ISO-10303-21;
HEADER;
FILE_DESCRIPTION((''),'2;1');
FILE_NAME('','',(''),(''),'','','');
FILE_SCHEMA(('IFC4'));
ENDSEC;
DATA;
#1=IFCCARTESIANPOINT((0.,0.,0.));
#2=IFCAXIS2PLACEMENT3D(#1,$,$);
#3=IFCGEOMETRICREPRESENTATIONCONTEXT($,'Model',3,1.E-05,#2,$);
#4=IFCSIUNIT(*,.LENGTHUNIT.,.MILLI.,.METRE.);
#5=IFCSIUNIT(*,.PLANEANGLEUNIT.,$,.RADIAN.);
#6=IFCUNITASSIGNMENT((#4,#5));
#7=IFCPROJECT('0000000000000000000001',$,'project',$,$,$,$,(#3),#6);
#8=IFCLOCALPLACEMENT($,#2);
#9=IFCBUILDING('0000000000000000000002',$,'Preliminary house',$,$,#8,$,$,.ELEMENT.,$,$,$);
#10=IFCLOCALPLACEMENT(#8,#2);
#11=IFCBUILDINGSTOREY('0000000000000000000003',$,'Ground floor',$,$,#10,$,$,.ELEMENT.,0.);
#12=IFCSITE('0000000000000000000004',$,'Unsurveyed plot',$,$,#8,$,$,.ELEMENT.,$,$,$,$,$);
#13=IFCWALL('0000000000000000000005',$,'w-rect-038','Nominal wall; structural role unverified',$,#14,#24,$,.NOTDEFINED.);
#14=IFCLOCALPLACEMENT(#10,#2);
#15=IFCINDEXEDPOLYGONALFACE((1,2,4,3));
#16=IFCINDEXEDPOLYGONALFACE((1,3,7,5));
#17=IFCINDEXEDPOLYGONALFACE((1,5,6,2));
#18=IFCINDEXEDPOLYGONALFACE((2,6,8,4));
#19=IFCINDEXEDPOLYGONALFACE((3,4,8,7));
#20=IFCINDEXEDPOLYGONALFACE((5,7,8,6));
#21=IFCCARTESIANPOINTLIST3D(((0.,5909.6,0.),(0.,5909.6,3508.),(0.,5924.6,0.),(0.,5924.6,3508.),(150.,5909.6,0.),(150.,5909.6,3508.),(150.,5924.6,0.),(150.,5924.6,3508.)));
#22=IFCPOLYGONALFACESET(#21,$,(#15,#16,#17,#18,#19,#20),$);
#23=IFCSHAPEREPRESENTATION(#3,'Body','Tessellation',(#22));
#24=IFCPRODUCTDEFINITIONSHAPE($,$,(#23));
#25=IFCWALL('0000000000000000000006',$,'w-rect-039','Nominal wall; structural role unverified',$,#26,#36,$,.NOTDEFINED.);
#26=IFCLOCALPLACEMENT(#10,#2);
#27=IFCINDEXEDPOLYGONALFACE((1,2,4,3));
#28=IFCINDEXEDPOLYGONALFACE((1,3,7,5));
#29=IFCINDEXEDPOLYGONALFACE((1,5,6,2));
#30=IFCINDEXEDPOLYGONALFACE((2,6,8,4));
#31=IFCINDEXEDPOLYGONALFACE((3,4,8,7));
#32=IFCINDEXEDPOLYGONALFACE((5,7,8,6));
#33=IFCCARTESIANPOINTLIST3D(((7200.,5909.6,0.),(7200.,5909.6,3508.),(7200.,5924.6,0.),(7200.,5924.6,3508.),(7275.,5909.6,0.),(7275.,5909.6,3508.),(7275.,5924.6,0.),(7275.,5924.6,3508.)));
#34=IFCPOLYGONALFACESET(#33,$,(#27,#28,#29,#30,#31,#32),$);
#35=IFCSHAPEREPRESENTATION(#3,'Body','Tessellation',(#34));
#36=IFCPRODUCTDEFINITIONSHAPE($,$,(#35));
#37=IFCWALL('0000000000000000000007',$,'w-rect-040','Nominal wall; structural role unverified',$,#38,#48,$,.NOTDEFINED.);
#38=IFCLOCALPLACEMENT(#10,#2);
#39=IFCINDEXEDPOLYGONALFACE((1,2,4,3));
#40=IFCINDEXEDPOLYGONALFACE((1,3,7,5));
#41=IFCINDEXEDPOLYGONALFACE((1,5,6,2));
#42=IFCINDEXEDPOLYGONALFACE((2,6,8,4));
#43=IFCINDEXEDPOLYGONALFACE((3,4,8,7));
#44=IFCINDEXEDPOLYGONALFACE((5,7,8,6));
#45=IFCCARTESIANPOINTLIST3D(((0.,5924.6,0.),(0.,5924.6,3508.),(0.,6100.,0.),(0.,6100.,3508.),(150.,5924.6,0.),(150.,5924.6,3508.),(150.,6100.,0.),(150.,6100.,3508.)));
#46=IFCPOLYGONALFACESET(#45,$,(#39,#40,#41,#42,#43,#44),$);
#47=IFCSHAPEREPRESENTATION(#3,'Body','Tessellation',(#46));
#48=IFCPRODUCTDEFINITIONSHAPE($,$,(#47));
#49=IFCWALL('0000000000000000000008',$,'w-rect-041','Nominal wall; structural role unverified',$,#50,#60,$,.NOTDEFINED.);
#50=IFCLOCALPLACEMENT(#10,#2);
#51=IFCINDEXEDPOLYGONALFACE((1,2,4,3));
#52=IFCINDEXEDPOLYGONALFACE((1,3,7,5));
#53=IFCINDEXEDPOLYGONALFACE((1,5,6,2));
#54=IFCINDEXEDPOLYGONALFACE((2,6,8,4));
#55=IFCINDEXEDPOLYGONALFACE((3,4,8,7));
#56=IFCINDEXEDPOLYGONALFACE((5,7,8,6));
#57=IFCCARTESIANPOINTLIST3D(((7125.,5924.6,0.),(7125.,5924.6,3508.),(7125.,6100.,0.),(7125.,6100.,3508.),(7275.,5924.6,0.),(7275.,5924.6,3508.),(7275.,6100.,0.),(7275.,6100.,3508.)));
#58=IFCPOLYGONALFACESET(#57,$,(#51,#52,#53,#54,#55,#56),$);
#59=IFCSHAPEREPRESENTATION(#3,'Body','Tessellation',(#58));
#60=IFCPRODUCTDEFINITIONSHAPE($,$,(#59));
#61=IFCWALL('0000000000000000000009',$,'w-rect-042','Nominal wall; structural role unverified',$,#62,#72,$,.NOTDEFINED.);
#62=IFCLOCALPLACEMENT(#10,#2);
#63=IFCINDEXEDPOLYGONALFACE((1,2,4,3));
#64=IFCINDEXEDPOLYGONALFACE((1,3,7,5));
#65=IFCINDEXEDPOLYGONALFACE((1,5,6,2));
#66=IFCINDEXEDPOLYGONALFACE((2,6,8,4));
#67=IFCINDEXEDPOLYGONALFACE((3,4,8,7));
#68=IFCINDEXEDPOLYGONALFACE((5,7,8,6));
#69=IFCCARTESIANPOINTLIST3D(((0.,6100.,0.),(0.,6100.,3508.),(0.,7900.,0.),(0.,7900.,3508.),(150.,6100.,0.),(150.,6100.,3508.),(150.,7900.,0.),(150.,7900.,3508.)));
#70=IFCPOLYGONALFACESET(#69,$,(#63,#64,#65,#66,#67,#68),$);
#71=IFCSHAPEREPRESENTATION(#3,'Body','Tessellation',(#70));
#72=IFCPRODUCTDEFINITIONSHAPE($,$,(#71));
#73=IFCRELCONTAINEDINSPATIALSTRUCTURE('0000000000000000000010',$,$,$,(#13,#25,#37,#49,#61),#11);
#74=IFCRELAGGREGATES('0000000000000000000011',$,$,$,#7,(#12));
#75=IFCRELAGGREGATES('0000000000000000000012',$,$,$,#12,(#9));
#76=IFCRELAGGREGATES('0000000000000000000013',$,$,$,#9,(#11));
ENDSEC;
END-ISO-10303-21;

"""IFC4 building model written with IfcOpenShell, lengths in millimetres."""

from ifc_helpers import new_model, si_unit, origin, place, context, project, spatial, polyline, outline, extrude, element, save


model = new_model("IFC4")

# Units and contexts
model_context = context("Model", 3, precision=1e-05, world=origin())
ifc_project = project(units=[si_unit("LENGTHUNIT", "METRE", prefix="MILLI"), si_unit("PLANEANGLEUNIT", "RADIAN")], contexts=[model_context])

# Site, building, storey
placement_1 = place(None, origin())
site = spatial("IfcSite", under=ifc_project, at=placement_1, Name="Unsurveyed plot", CompositionType="ELEMENT")
building = spatial("IfcBuilding", under=site, at=placement_1, Name="Preliminary house", CompositionType="ELEMENT")
placement_2 = place(placement_1, origin())
storey = spatial("IfcBuildingStorey", under=building, at=placement_2, Name="Ground floor", CompositionType="ELEMENT", Elevation=0.0)

# Walls
element("IfcWall", 1, at=placement_2, inside=storey, Name="w-rect-038", Description="Nominal wall; structural role unverified", PredefinedType="NOTDEFINED", context=model_context, shape_type="SweptSolid", body=[
    extrude(outline(polyline([(0.0, 5909.6), (150.0, 5909.6), (150.0, 5924.6), (0.0, 5924.6), (0.0, 5909.6)])), origin(), (0.0, 0.0, 1.0), 3508.0),
])
element("IfcWall", 2, at=placement_2, inside=storey, Name="w-rect-039", Description="Nominal wall; structural role unverified", PredefinedType="NOTDEFINED", context=model_context, shape_type="SweptSolid", body=[
    extrude(outline(polyline([(7200.0, 5909.6), (7275.0, 5909.6), (7275.0, 5924.6), (7200.0, 5924.6), (7200.0, 5909.6)])), origin(), (0.0, 0.0, 1.0), 3508.0),
])
element("IfcWall", 3, at=placement_2, inside=storey, Name="w-rect-040", Description="Nominal wall; structural role unverified", PredefinedType="NOTDEFINED", context=model_context, shape_type="SweptSolid", body=[
    extrude(outline(polyline([(0.0, 5924.6), (150.0, 5924.6), (150.0, 6100.0), (0.0, 6100.0), (0.0, 5924.6)])), origin(), (0.0, 0.0, 1.0), 3508.0),
])
element("IfcWall", 4, at=placement_2, inside=storey, Name="w-rect-041", Description="Nominal wall; structural role unverified", PredefinedType="NOTDEFINED", context=model_context, shape_type="SweptSolid", body=[
    extrude(outline(polyline([(7125.0, 5924.6), (7275.0, 5924.6), (7275.0, 6100.0), (7125.0, 6100.0), (7125.0, 5924.6)])), origin(), (0.0, 0.0, 1.0), 3508.0),
])
element("IfcWall", 5, at=placement_2, inside=storey, Name="w-rect-042", Description="Nominal wall; structural role unverified", PredefinedType="NOTDEFINED", context=model_context, shape_type="SweptSolid", body=[
    extrude(outline(polyline([(0.0, 6100.0), (150.0, 6100.0), (150.0, 7900.0), (0.0, 7900.0), (0.0, 6100.0)])), origin(), (0.0, 0.0, 1.0), 3508.0),
])

save(model, "model.ifc")
